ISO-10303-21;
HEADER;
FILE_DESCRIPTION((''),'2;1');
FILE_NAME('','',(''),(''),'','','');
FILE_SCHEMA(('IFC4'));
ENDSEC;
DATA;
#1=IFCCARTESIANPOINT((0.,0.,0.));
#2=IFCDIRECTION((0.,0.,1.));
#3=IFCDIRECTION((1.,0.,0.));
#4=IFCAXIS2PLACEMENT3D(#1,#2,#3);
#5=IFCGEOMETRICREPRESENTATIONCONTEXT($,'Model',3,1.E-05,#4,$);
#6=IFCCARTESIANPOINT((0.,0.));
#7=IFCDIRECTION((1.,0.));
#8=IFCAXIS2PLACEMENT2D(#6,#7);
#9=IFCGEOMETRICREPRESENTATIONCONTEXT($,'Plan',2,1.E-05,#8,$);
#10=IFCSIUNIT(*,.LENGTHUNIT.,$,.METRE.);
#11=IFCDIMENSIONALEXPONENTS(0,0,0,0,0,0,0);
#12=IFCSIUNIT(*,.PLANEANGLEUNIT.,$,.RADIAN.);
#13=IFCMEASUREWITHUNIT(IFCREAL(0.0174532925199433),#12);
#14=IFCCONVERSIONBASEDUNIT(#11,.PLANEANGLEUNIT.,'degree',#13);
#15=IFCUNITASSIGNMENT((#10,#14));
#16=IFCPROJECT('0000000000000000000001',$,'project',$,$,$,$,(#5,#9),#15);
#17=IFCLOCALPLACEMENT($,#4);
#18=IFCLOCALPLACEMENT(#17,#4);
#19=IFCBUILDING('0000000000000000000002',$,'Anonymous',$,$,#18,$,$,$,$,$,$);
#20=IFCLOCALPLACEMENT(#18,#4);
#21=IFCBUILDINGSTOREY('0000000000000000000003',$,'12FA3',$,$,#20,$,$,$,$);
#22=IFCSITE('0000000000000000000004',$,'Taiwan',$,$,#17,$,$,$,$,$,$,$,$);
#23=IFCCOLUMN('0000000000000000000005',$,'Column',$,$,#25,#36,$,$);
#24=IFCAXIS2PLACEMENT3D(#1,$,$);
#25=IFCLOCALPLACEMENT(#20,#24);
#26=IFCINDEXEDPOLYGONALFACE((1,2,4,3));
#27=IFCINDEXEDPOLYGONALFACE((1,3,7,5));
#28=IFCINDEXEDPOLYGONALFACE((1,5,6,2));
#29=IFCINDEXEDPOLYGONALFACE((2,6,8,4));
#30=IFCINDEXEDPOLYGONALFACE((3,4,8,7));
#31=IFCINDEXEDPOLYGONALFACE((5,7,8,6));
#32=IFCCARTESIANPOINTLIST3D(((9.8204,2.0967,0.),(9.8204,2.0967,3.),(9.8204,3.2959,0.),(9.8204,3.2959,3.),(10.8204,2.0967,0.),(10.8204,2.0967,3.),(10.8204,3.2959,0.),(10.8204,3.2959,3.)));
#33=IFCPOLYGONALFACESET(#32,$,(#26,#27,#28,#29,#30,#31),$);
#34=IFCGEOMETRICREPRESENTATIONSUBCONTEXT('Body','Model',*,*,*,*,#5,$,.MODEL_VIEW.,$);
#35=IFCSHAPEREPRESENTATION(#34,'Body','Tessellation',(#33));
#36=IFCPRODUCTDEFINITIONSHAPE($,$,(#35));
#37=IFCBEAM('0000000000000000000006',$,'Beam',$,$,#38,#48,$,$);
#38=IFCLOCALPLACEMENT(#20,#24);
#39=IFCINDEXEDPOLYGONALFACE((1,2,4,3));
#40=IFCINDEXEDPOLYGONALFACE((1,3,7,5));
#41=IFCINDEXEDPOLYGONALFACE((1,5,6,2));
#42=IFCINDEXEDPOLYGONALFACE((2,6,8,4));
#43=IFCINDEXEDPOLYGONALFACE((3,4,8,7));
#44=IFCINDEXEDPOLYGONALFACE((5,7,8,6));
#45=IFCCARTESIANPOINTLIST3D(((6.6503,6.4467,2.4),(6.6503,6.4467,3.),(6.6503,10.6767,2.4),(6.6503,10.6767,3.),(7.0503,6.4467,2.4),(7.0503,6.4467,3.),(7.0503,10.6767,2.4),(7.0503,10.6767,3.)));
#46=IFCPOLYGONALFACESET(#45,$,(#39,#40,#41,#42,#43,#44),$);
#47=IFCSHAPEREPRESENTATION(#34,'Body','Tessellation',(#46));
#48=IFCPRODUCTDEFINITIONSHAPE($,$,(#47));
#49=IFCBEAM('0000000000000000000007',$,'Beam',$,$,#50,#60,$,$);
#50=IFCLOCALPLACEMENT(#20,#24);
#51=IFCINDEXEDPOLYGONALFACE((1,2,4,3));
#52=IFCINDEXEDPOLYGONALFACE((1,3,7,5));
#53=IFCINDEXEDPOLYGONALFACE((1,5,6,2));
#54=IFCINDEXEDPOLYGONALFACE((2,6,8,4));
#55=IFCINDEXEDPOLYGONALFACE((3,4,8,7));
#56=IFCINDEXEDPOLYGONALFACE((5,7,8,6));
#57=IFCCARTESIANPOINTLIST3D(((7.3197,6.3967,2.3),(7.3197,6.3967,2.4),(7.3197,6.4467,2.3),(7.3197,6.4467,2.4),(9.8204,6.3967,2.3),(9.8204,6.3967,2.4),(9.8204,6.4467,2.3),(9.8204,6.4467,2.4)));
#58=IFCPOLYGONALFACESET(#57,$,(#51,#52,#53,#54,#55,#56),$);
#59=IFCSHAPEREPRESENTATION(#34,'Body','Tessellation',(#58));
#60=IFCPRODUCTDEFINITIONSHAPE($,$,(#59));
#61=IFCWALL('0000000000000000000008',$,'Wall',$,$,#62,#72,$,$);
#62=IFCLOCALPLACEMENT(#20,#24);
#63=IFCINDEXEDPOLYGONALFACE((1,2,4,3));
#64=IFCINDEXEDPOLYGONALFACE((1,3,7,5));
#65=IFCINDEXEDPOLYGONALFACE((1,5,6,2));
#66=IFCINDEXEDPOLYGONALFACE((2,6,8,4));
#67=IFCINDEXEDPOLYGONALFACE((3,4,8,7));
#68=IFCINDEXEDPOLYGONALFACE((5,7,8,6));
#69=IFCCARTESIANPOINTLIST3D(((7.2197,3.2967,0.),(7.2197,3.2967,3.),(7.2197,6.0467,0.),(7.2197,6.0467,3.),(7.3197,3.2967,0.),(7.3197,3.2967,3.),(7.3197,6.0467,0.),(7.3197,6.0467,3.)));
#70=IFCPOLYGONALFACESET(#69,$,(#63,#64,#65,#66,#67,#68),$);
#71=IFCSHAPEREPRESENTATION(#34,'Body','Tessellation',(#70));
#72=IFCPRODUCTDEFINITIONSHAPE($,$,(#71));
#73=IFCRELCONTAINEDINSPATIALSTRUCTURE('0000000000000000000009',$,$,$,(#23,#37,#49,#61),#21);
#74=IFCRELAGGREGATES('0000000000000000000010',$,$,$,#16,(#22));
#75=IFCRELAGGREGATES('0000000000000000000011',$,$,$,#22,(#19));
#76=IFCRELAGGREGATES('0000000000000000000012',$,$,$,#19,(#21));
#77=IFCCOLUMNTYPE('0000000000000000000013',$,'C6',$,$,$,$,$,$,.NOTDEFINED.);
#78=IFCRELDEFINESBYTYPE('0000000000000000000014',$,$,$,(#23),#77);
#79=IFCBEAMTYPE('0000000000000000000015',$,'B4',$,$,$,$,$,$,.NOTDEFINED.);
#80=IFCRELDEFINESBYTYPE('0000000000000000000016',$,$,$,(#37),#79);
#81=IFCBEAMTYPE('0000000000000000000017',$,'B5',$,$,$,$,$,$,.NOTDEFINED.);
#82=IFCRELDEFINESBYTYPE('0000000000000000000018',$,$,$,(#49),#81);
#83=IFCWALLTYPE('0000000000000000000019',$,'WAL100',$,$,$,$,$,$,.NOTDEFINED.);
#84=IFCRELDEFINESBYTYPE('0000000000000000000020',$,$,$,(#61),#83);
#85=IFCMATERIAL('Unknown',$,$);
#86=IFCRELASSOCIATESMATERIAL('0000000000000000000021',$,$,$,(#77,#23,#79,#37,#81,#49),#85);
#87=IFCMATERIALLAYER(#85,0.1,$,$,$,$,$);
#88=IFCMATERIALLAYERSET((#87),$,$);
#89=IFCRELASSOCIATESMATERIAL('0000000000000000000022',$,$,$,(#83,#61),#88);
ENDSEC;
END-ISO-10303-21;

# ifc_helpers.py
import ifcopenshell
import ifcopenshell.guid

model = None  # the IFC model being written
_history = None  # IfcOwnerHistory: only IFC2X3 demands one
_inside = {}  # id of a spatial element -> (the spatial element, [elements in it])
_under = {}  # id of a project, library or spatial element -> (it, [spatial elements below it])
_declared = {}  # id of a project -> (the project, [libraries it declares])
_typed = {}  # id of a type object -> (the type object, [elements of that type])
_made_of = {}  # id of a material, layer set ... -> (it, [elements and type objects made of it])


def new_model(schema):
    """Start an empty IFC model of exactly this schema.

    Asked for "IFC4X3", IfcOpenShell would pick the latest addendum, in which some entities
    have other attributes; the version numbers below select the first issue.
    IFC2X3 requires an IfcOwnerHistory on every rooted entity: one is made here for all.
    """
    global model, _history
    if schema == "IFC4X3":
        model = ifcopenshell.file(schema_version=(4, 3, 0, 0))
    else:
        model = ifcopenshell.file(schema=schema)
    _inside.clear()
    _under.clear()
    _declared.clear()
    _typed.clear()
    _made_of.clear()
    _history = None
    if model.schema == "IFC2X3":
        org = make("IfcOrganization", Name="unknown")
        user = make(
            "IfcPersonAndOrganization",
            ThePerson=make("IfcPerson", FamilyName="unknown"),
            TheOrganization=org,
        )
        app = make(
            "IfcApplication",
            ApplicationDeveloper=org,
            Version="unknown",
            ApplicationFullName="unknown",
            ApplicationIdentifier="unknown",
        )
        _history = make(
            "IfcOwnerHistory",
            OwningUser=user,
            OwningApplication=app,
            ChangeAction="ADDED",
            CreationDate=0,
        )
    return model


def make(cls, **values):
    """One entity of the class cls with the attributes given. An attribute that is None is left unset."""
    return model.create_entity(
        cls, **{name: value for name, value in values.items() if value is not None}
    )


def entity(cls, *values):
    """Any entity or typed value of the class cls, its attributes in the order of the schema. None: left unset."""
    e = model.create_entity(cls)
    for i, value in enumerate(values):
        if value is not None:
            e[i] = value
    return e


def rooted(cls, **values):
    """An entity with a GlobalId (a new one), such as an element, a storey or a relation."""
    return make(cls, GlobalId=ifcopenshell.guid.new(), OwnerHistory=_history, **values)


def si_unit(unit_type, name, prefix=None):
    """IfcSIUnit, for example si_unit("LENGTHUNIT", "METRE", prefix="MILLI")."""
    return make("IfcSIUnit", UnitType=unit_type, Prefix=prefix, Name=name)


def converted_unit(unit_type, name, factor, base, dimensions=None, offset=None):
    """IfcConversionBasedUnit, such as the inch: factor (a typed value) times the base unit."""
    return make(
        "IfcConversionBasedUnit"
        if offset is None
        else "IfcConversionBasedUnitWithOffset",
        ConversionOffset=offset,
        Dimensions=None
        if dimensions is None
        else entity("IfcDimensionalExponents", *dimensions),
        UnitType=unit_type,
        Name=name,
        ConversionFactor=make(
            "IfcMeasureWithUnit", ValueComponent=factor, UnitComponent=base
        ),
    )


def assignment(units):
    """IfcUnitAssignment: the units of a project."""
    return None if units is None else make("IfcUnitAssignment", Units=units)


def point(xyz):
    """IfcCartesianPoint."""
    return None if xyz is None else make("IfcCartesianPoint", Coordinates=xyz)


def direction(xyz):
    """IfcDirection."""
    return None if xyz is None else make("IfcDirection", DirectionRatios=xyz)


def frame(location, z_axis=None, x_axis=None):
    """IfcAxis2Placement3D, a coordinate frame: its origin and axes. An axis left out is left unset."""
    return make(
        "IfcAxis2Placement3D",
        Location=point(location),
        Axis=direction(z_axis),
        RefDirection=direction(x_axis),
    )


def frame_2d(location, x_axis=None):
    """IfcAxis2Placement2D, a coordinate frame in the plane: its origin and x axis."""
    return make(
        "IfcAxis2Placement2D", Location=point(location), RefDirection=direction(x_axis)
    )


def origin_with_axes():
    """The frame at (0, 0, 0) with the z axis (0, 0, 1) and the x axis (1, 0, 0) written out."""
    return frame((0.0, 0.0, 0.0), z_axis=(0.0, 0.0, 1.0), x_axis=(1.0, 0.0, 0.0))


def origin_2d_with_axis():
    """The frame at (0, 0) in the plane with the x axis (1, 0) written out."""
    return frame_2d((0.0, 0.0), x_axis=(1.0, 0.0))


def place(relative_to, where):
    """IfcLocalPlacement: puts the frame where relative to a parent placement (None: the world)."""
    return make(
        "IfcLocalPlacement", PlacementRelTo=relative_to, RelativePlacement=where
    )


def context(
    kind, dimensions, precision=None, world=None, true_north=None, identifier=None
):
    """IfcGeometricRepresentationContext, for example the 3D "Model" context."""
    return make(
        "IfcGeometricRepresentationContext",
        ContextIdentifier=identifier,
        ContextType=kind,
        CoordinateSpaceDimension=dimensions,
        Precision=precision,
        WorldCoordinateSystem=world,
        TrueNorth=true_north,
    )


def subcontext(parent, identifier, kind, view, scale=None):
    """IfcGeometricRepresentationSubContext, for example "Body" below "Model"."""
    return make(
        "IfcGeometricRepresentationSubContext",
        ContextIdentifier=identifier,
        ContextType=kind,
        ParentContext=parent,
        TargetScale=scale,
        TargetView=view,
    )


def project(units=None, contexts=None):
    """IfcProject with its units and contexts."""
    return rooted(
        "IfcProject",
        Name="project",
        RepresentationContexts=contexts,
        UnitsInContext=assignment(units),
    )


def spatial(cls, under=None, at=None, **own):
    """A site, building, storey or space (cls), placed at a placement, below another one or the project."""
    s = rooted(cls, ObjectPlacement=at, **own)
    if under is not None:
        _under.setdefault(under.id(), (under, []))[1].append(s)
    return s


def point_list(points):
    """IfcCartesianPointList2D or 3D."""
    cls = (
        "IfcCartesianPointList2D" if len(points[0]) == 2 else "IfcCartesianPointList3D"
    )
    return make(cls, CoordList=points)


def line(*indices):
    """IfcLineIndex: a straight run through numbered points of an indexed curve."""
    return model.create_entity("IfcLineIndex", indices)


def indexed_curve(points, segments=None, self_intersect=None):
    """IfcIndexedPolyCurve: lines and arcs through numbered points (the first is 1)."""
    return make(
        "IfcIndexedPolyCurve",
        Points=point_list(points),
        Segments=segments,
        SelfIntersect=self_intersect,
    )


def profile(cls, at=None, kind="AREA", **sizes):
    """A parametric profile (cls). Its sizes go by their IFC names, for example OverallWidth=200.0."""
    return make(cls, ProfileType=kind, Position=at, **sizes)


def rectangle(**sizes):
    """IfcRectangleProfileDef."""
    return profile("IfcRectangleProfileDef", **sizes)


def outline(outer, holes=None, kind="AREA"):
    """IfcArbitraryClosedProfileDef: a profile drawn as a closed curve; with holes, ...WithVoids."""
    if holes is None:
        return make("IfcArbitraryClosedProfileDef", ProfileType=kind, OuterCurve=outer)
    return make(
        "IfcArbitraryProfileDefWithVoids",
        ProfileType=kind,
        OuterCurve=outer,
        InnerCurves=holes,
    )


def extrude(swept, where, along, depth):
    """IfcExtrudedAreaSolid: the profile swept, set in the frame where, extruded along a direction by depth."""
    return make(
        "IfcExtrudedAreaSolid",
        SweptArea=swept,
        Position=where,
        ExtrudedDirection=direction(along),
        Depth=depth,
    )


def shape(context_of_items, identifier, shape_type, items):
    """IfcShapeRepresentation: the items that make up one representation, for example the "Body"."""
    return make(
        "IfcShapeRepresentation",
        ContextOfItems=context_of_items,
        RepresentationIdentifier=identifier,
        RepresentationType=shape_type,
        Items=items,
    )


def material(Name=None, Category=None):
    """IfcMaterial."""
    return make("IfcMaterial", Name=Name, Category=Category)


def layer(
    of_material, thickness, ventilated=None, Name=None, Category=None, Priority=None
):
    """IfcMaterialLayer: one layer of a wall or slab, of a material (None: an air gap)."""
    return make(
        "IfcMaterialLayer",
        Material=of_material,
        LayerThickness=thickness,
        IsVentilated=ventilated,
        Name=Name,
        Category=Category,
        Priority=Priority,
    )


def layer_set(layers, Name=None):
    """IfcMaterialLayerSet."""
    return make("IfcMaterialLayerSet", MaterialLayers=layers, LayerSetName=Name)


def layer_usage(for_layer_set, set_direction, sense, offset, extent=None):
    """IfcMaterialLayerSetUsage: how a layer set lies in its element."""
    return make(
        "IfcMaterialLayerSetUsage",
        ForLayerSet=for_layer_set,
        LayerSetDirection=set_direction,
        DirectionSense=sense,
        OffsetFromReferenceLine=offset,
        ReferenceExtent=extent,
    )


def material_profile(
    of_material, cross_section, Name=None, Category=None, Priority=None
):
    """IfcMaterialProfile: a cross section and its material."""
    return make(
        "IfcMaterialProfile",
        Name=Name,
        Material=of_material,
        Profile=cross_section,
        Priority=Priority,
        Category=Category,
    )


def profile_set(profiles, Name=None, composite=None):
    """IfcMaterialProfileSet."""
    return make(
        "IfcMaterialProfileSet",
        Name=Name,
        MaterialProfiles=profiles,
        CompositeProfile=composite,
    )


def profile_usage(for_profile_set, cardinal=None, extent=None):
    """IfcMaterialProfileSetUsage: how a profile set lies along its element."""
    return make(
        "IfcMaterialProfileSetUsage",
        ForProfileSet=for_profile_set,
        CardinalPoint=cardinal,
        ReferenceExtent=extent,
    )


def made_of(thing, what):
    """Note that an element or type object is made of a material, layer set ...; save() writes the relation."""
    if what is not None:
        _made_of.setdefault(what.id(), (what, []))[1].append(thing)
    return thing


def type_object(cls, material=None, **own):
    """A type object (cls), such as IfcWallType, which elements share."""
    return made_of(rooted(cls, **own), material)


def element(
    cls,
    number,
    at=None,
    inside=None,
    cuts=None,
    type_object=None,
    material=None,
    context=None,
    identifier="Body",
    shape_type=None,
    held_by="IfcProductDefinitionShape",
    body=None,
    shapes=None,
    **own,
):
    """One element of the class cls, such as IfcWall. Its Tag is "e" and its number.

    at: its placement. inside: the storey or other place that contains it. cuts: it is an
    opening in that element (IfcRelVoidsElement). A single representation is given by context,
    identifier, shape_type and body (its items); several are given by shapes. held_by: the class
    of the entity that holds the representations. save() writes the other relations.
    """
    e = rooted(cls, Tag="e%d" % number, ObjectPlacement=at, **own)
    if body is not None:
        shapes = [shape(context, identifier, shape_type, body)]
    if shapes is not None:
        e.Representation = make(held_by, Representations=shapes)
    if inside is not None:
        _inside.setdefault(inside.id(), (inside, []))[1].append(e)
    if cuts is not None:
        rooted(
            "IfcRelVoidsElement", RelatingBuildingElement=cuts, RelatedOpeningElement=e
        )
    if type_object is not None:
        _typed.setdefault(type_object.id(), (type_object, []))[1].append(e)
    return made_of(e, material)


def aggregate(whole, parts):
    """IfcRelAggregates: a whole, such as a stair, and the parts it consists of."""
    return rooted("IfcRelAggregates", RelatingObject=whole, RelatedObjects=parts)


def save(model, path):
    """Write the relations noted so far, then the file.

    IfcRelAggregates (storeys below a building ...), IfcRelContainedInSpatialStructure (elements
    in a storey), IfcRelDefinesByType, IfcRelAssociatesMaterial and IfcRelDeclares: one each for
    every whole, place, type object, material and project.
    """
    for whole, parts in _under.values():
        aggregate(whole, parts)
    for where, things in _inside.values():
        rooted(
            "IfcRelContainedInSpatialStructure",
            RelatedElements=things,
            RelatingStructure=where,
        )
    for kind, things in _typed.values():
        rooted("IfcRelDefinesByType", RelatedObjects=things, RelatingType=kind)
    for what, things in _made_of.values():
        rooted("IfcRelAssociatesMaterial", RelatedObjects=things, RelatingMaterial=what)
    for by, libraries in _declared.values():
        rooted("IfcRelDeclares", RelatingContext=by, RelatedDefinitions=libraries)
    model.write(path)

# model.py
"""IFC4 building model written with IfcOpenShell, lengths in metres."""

from ifc_helpers import new_model, entity, si_unit, converted_unit, frame, origin_with_axes, origin_2d_with_axis, place, context, subcontext, project, spatial, line, indexed_curve, rectangle, outline, extrude, material, layer, layer_set, layer_usage, material_profile, profile_set, profile_usage, type_object, element, save


model = new_model("IFC4")

# Units and contexts
model_context = context("Model", 3, precision=1e-05, world=origin_with_axes())
plan_context = context("Plan", 2, precision=1e-05, world=origin_2d_with_axis())
body_context_1 = subcontext(model_context, "Body", "Model", "MODEL_VIEW")
ifc_project = project(units=[si_unit("LENGTHUNIT", "METRE"), converted_unit("PLANEANGLEUNIT", "degree", entity("IfcReal", 0.0174532925199433), si_unit("PLANEANGLEUNIT", "RADIAN"), dimensions=[0, 0, 0, 0, 0, 0, 0])], contexts=[model_context, plan_context])

# Site, building, storey
site_placement = place(None, origin_with_axes())
site = spatial("IfcSite", under=ifc_project, at=site_placement, Name="Taiwan")
building_placement = place(site_placement, origin_with_axes())
building = spatial("IfcBuilding", under=site, at=building_placement, Name="Anonymous")
storey_placement = place(building_placement, origin_with_axes())
storey = spatial("IfcBuildingStorey", under=building, at=storey_placement, Name="12FA3")

# Column
ifc_material = material(Name="Unknown")
ifc_material_profile_1 = material_profile(ifc_material, outline(indexed_curve([(0.0, 1.1992), (1.0, 1.1992), (1.0, 0.0), (0.0, 0.0), (0.0, 1.1992)])))
ifc_profile_set_1 = profile_set([ifc_material_profile_1])
ifc_profile_usage_1 = profile_usage(ifc_profile_set_1, cardinal=5)
column_type = type_object("IfcColumnType", Name="C6", PredefinedType="NOTDEFINED", material=ifc_profile_set_1)
column_placement = place(storey_placement, frame((9.8204, 2.0967, 0.0), z_axis=(0.0, 0.0, 1.0), x_axis=(1.0, 0.0, 0.0)))
element("IfcColumn", 1, at=column_placement, inside=storey, type_object=column_type, material=ifc_profile_usage_1, Name="Column", context=body_context_1, shape_type="SweptSolid", body=[
    extrude(outline(indexed_curve([(0.0, 1.1992), (1.0, 1.1992), (1.0, 0.0), (0.0, 0.0), (0.0, 1.1992)])), origin_with_axes(), (0.0, 0.0, 1.0), 3.0),
])

# Beams
ifc_material_profile_2 = material_profile(ifc_material, rectangle(XDim=0.4, YDim=0.6, kind="CURVE"))
ifc_profile_set_2 = profile_set([ifc_material_profile_2])
ifc_profile_usage_2 = profile_usage(ifc_profile_set_2, cardinal=7)
beam_type_1 = type_object("IfcBeamType", Name="B4", PredefinedType="NOTDEFINED", material=ifc_profile_set_2)
beam_1_placement = place(storey_placement, frame((6.6503, 6.4467, 3.0), z_axis=(0.0, 1.0, 0.0), x_axis=(-1.0, 0.0, 0.0)))
element("IfcBeam", 2, at=beam_1_placement, inside=storey, type_object=beam_type_1, material=ifc_profile_usage_2, Name="Beam", context=body_context_1, shape_type="SweptSolid", body=[
    extrude(rectangle(XDim=0.4, YDim=0.6, kind="CURVE"), frame((-0.2, -0.3, 0.0), z_axis=(0.0, 0.0, 1.0), x_axis=(1.0, 0.0, 0.0)), (0.0, 0.0, 1.0), 4.23),
])
ifc_material_profile_3 = material_profile(ifc_material, rectangle(XDim=0.05, YDim=0.1, kind="CURVE"))
ifc_profile_set_3 = profile_set([ifc_material_profile_3])
ifc_profile_usage_3 = profile_usage(ifc_profile_set_3, cardinal=7)
beam_type_2 = type_object("IfcBeamType", Name="B5", PredefinedType="NOTDEFINED", material=ifc_profile_set_3)
beam_2_placement = place(storey_placement, frame((7.3197, 6.4467, 2.4), z_axis=(1.0, 0.0, 0.000001), x_axis=(0.0, 1.0, 0.0)))
element("IfcBeam", 3, at=beam_2_placement, inside=storey, type_object=beam_type_2, material=ifc_profile_usage_3, Name="Beam", context=body_context_1, shape_type="SweptSolid", body=[
    extrude(rectangle(XDim=0.05, YDim=0.1, kind="CURVE"), frame((-0.025, -0.05, 0.0), z_axis=(0.0, 0.0, 1.0), x_axis=(1.0, 0.0, 0.0)), (0.0, 0.0, 1.0), 2.5007),
])

# Wall
ifc_layer_1 = layer(ifc_material, 0.1)
ifc_layer_set_1 = layer_set([ifc_layer_1])
ifc_layer_usage_1 = layer_usage(ifc_layer_set_1, "AXIS2", "POSITIVE", 0.0)
wall_type_1 = type_object("IfcWallType", Name="WAL100", PredefinedType="NOTDEFINED", material=ifc_layer_set_1)
wall_1_placement = place(storey_placement, frame((7.3197, 3.2967, 0.0), z_axis=(0.0, 0.0, 1.0), x_axis=(0.0, 1.0, 0.0)))
element("IfcWall", 4, at=wall_1_placement, inside=storey, type_object=wall_type_1, material=ifc_layer_usage_1, Name="Wall", context=body_context_1, shape_type="SweptSolid", body=[
    extrude(outline(indexed_curve([(0.0, 0.0), (0.0, 0.1), (2.75, 0.1), (2.75, 0.0)], segments=[line(1, 2, 3, 4, 1)])), origin_with_axes(), (0.0, 0.0, 1.0), 3.0),
])

save(model, "model.ifc")
